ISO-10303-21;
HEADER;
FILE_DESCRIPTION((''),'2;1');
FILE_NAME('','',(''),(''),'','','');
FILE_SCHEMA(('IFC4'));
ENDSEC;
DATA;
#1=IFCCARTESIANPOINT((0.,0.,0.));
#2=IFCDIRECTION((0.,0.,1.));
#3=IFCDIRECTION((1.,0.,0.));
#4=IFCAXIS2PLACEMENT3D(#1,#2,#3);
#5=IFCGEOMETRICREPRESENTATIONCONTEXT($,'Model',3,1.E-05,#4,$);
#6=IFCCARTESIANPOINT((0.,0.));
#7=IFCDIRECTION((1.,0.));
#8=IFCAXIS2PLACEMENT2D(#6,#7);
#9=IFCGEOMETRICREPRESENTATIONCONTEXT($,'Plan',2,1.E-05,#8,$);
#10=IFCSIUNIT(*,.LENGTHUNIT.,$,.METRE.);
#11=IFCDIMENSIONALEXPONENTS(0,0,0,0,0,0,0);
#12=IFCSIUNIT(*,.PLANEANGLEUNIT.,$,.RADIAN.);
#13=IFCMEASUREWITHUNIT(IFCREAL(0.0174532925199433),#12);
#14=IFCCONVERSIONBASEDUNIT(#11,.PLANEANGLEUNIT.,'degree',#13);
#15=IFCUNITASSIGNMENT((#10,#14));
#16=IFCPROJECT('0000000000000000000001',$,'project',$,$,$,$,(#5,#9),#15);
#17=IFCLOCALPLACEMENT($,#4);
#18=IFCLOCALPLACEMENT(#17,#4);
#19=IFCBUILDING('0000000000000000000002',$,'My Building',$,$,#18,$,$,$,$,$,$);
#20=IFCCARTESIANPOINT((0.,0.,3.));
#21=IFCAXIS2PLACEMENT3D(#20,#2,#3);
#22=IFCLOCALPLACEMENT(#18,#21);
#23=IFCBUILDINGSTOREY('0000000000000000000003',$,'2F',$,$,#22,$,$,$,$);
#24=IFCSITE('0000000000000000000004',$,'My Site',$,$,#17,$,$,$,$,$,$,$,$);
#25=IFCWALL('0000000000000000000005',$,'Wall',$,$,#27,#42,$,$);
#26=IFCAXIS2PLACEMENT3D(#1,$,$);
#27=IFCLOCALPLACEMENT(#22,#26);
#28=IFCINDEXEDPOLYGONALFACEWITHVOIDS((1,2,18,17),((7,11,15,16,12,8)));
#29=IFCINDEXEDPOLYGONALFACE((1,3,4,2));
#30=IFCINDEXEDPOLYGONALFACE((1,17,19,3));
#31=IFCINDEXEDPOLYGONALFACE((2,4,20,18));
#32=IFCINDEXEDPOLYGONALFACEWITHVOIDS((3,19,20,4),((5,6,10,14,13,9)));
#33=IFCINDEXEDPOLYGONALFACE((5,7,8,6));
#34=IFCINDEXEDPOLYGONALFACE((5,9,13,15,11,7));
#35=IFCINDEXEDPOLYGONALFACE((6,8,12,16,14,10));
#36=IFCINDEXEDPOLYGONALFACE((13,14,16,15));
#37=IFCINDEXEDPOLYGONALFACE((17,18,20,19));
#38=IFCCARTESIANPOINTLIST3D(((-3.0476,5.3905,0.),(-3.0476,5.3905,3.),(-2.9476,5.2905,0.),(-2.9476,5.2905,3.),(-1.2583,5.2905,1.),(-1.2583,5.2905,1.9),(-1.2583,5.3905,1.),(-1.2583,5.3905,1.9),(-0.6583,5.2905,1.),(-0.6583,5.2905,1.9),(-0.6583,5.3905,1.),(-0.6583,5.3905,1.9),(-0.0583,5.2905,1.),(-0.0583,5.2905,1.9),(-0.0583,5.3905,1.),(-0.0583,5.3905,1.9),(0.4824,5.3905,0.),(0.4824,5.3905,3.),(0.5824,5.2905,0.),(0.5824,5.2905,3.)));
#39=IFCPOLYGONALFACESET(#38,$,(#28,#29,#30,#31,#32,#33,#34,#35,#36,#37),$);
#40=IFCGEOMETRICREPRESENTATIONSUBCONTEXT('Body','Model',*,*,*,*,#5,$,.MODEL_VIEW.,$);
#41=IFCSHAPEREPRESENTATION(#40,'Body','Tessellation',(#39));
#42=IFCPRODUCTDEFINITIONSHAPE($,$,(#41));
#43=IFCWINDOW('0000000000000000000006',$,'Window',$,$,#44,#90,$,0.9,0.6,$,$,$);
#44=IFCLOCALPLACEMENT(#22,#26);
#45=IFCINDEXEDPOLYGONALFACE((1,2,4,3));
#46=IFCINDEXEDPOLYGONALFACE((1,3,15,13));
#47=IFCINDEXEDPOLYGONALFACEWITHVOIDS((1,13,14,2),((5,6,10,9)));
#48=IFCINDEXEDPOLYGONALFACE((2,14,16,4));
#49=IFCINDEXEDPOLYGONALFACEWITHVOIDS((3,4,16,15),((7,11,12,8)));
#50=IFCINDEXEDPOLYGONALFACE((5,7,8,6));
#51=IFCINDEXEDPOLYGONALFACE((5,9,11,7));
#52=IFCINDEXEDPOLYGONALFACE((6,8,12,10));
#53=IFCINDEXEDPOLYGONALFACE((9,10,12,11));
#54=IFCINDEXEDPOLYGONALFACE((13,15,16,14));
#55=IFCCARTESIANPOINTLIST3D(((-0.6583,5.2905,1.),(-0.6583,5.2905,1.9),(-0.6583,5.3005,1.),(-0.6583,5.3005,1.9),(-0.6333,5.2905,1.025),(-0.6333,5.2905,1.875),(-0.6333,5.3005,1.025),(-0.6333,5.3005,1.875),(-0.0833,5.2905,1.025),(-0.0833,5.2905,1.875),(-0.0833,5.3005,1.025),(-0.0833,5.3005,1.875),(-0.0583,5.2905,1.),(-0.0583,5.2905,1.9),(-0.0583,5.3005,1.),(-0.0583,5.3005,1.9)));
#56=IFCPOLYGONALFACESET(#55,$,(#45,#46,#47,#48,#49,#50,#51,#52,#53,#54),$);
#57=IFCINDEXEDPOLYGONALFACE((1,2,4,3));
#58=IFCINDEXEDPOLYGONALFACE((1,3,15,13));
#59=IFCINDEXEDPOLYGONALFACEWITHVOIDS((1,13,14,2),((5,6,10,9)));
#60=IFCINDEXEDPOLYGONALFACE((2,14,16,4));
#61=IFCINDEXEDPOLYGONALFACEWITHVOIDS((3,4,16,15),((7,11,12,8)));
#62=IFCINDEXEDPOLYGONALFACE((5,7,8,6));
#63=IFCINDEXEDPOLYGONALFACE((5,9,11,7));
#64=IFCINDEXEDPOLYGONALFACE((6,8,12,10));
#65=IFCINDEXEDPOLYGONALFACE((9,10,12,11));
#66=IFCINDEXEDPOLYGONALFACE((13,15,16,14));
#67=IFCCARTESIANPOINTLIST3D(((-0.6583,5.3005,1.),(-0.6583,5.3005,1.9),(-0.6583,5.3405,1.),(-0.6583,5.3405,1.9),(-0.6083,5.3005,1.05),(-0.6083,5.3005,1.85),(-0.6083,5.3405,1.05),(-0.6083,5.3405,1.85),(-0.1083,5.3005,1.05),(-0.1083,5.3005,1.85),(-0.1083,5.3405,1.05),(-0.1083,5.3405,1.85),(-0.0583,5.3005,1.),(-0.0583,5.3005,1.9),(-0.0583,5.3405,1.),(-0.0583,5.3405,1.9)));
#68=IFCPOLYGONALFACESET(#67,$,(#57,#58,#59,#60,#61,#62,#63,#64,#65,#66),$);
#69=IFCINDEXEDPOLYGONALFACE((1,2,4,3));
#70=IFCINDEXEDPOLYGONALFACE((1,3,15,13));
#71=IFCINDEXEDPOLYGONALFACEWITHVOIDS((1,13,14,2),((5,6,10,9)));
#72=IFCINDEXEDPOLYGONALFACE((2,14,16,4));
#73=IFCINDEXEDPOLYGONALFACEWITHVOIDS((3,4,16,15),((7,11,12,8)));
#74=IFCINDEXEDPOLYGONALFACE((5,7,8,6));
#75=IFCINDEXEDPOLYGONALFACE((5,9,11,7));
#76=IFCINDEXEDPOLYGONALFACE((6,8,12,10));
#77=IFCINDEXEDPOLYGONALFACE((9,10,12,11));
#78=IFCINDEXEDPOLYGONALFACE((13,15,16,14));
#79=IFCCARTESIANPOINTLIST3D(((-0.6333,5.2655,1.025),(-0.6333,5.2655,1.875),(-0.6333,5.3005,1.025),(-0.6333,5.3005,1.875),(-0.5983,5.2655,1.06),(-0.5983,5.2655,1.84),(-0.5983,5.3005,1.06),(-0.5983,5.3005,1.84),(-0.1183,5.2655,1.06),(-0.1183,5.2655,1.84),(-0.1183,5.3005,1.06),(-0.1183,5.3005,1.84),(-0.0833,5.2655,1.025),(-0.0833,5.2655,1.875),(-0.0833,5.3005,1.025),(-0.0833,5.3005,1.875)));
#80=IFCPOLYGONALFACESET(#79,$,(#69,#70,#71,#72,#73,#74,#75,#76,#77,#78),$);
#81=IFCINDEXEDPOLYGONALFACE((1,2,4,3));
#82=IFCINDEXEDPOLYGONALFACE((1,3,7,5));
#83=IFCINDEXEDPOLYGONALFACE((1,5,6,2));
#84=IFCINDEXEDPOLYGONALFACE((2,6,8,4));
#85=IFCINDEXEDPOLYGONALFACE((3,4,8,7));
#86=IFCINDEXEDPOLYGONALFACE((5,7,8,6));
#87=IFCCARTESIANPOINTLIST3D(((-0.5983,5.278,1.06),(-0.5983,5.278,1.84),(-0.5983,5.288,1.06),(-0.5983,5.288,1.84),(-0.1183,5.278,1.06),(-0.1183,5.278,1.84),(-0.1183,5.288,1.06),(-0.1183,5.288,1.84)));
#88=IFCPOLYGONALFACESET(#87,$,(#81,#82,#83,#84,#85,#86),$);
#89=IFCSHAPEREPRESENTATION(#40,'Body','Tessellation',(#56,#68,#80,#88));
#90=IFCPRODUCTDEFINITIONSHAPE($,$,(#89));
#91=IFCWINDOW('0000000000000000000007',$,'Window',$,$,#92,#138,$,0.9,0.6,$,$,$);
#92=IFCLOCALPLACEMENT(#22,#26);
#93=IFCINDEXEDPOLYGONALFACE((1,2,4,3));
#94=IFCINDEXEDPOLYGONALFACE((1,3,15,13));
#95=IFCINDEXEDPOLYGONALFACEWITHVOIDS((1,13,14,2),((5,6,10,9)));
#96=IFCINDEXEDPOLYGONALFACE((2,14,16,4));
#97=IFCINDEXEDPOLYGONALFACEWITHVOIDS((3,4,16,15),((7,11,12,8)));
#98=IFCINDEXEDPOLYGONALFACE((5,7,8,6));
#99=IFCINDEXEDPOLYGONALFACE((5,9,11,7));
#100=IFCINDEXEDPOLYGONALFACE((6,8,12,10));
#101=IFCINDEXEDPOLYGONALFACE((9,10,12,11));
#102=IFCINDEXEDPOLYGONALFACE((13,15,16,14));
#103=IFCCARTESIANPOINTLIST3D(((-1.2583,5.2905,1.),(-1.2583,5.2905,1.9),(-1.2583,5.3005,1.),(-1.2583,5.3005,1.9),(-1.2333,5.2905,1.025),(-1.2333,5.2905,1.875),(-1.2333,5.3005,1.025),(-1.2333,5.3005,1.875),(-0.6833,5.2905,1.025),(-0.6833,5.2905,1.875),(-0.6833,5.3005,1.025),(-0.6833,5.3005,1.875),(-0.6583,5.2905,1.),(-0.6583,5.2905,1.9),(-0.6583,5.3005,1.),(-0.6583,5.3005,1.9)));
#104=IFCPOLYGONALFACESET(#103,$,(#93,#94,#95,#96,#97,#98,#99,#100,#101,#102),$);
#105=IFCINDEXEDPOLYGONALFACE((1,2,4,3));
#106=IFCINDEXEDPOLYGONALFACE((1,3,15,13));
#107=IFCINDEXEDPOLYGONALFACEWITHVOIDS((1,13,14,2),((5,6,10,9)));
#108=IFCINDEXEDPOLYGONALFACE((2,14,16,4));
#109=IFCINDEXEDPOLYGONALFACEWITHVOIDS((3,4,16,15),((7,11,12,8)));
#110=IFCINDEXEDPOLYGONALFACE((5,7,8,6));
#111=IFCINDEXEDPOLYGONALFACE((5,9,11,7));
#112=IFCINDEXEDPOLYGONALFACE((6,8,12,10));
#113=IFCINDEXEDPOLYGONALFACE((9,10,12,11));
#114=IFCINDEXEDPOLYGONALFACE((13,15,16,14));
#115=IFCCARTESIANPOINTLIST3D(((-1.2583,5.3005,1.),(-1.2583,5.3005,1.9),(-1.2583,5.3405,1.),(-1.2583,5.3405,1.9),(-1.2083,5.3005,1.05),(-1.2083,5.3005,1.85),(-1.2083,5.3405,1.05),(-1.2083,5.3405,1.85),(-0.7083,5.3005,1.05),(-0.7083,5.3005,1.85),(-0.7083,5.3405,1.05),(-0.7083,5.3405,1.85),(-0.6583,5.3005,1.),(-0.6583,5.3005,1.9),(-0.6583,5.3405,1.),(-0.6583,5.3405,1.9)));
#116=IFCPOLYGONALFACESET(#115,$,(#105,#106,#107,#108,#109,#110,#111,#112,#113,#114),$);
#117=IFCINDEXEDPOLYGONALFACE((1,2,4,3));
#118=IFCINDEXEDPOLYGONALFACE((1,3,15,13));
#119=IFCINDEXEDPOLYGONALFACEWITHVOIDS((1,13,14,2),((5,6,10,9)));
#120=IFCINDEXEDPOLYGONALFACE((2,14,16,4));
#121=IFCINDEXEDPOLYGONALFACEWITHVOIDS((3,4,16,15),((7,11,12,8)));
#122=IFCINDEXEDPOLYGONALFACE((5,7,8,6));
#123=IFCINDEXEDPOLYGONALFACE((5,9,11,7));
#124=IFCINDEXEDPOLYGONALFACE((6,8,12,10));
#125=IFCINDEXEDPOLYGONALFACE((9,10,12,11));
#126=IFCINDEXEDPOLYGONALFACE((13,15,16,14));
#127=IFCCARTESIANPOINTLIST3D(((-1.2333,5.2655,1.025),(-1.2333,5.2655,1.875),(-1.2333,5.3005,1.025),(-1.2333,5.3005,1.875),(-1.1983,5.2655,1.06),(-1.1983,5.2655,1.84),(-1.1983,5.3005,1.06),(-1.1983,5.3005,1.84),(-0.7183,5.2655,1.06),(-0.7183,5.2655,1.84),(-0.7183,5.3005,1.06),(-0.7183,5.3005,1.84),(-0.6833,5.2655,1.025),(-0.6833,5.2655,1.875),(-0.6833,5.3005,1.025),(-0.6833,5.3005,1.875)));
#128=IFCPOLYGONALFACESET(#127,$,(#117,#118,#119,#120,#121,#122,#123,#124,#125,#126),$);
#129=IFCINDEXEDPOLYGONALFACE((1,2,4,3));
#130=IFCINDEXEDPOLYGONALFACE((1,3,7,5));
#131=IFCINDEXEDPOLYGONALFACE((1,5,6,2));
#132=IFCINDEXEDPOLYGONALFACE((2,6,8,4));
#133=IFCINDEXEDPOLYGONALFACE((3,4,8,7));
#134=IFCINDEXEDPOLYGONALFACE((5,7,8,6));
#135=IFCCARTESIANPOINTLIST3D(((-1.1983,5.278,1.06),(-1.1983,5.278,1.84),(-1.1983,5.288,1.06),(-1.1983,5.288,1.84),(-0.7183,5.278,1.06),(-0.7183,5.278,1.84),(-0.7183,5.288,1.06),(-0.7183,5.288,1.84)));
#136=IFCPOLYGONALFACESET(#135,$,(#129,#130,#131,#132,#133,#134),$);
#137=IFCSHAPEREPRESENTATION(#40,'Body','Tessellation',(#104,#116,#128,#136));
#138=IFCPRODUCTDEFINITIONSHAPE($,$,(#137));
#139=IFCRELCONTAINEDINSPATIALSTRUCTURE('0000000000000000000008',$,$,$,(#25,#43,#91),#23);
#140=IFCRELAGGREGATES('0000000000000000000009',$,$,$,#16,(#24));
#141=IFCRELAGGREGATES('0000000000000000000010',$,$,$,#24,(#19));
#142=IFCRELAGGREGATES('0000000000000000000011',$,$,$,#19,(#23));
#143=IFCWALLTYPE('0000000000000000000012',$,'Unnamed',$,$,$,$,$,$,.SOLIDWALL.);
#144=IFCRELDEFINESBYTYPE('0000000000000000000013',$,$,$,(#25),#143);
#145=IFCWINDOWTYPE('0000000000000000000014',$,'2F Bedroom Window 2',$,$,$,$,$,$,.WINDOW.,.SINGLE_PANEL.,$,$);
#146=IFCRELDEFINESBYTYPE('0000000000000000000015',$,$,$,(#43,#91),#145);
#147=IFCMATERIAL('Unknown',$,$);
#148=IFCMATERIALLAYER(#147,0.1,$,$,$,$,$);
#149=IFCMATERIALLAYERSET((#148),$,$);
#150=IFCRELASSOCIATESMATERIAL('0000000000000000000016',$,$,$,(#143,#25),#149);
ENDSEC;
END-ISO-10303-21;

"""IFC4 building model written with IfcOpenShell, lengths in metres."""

from ifc_helpers import new_model, entity, si_unit, converted_unit, frame, origin_with_axes, origin_2d_with_axis, place, context, subcontext, project, spatial, line, indexed_curve, outline, extrude, shape, source, transform, mapped, material, layer, layer_set, layer_usage, type_object, type_shapes, element, fill, save


model = new_model("IFC4")

# Units and contexts
model_context = context("Model", 3, precision=1e-05, world=origin_with_axes())
plan_context = context("Plan", 2, precision=1e-05, world=origin_2d_with_axis())
body_context_1 = subcontext(model_context, "Body", "Model", "MODEL_VIEW")
body_context_2 = subcontext(plan_context, "Body", "Plan", "PLAN_VIEW")
ifc_project = project(units=[si_unit("LENGTHUNIT", "METRE"), converted_unit("PLANEANGLEUNIT", "degree", entity("IfcReal", 0.0174532925199433), si_unit("PLANEANGLEUNIT", "RADIAN"), dimensions=[0, 0, 0, 0, 0, 0, 0])], contexts=[model_context, plan_context])

# Site, building, storey
site_placement = place(None, origin_with_axes())
site = spatial("IfcSite", under=ifc_project, at=site_placement, Name="My Site")
building_placement = place(site_placement, origin_with_axes())
building = spatial("IfcBuilding", under=site, at=building_placement, Name="My Building")
storey_placement = place(building_placement, frame((0.0, 0.0, 3.0), z_axis=(0.0, 0.0, 1.0), x_axis=(1.0, 0.0, 0.0)))
storey = spatial("IfcBuildingStorey", under=building, at=storey_placement, Name="2F")

# Shared definitions
ifc_material = material(Name="Unknown")

# Shared definitions
ifc_layer = layer(ifc_material, 0.1)
ifc_layer_set = layer_set([ifc_layer])
wall_type = type_object("IfcWallType", Name="Unnamed", PredefinedType="SOLIDWALL", material=ifc_layer_set)

# Wall, openings, windows
ifc_layer_usage_1 = layer_usage(ifc_layer_set, "AXIS2", "POSITIVE", 0.0)
wall_1_placement = place(storey_placement, frame((0.4824, 5.3905, 0.0), z_axis=(0.0, 0.0, 1.0), x_axis=(-1.0, 0.0, 0.0)))
wall_1 = element("IfcWall", 1, at=wall_1_placement, inside=storey, type_object=wall_type, material=ifc_layer_usage_1, Name="Wall", context=body_context_1, shape_type="SweptSolid", body=[
    extrude(outline(indexed_curve([(0.0, 0.0), (-0.1, 0.1), (3.43, 0.1), (3.53, 0.0)], segments=[line(1, 2, 3, 4, 1)])), origin_with_axes(), (0.0, 0.0, 1.0), 3.0),
])
shared_shape_1 = source(origin_with_axes(), body_context_1, "Body", "SweptSolid", [
    extrude(outline(indexed_curve([(0.0, 0.0), (0.6, 0.0), (0.6, 0.9), (0.0, 0.9)], segments=[line(1, 2, 3, 4, 1)])), frame((0.0, -0.6, 0.0), z_axis=(0.0, -1.0, 0.0), x_axis=(1.0, 0.0, 0.0)), (0.0, 0.0, -1.0), 1.2),
])
opening_1_placement = place(wall_1_placement, frame((0.5406, 0.0, 1.0), z_axis=(0.0, 0.0, 1.0), x_axis=(1.0, 0.0, 0.0)))
opening_1 = element("IfcOpeningElement", 2, at=opening_1_placement, cuts=wall_1, PredefinedType="OPENING", context=body_context_1, shape_type="MappedRepresentation", body=[
    mapped(shared_shape_1, transform((0.0, 0.0, 0.0), x_axis=(1.0, 0.0, 0.0), y_axis=(0.0, 1.0, 0.0), z_axis=(0.0, 0.0, 1.0), scale=1.0)),
])
opening_2_placement = place(wall_1_placement, frame((1.1406, 0.0, 1.0), z_axis=(0.0, 0.0, 1.0), x_axis=(1.0, 0.0, 0.0)))
opening_2 = element("IfcOpeningElement", 3, at=opening_2_placement, cuts=wall_1, PredefinedType="OPENING", context=body_context_1, shape_type="MappedRepresentation", body=[
    mapped(shared_shape_1, transform((0.0, 0.0, 0.0), x_axis=(1.0, 0.0, 0.0), y_axis=(0.0, 1.0, 0.0), z_axis=(0.0, 0.0, 1.0), scale=1.0)),
])
window_type_1 = type_object("IfcWindowType", Name="2F Bedroom Window 2", PartitioningType="SINGLE_PANEL", PredefinedType="WINDOW")
shared_shape_2 = source(origin_with_axes(), body_context_1, "Body", "SweptSolid", [
    extrude(outline(indexed_curve([(0.0, 0.0), (0.6, 0.0), (0.6, 0.9), (0.0, 0.9)], segments=[line(1, 2, 3, 4, 1)]), holes=[indexed_curve([(0.025, 0.025), (0.575, 0.025), (0.575, 0.875), (0.025, 0.875)], segments=[line(1, 2, 3, 4, 1)])]), frame((0.0, 0.09, 0.0), z_axis=(0.0, -1.0, 0.0), x_axis=(1.0, 0.0, 0.0)), (0.0, 0.0, -1.0), 0.01),
    extrude(outline(indexed_curve([(0.0, 0.0), (0.6, 0.0), (0.6, 0.9), (0.0, 0.9)], segments=[line(1, 2, 3, 4, 1)]), holes=[indexed_curve([(0.05, 0.05), (0.55, 0.05), (0.55, 0.85), (0.05, 0.85)], segments=[line(1, 2, 3, 4, 1)])]), frame((0.0, 0.05, 0.0), z_axis=(0.0, -1.0, 0.0), x_axis=(1.0, 0.0, 0.0)), (0.0, 0.0, -1.0), 0.04),
    extrude(outline(indexed_curve([(0.0, 0.0), (0.55, 0.0), (0.55, 0.85), (0.0, 0.85)], segments=[line(1, 2, 3, 4, 1)]), holes=[indexed_curve([(0.035, 0.035), (0.515, 0.035), (0.515, 0.815), (0.035, 0.815)], segments=[line(1, 2, 3, 4, 1)])]), frame((0.025, 0.09, 0.025), z_axis=(0.0, -1.0, 0.0), x_axis=(1.0, 0.0, 0.0)), (0.0, 0.0, -1.0), 0.035),
    extrude(outline(indexed_curve([(0.035, 0.035), (0.515, 0.035), (0.515, 0.815), (0.035, 0.815)], segments=[line(1, 2, 3, 4, 1)])), frame((0.025, 0.1025, 0.025), z_axis=(0.0, -1.0, 0.0), x_axis=(1.0, 0.0, 0.0)), (0.0, 0.0, -1.0), 0.01),
])
shared_shape_3 = source(origin_with_axes(), body_context_2, "Body", "Curve2D", [
    entity("IfcIndexedPolyCurve", entity("IfcCartesianPointList2D", [[0.05, 0.05], [0.55, 0.05]])),
    entity("IfcIndexedPolyCurve", entity("IfcCartesianPointList2D", [[0.0, 0.1], [0.025, 0.1], [0.025, 0.09], [0.05, 0.09], [0.05, 0.05], [0.0, 0.05]]), [entity("IfcLineIndex", [1, 2, 3, 4, 5, 6, 1])]),
    entity("IfcIndexedPolyCurve", entity("IfcCartesianPointList2D", [[0.6, 0.1], [0.575, 0.1], [0.575, 0.09], [0.55, 0.09], [0.55, 0.05], [0.6, 0.05]]), [entity("IfcLineIndex", [1, 2, 3, 4, 5, 6, 1])]),
    entity("IfcIndexedPolyCurve", entity("IfcCartesianPointList2D", [[0.025, 0.09], [0.06, 0.09], [0.06, 0.125], [0.025, 0.125]]), [entity("IfcLineIndex", [1, 2, 3, 4, 1])]),
    entity("IfcIndexedPolyCurve", entity("IfcCartesianPointList2D", [[0.575, 0.09], [0.54, 0.09], [0.54, 0.125], [0.575, 0.125]]), [entity("IfcLineIndex", [1, 2, 3, 4, 1])]),
    entity("IfcIndexedPolyCurve", entity("IfcCartesianPointList2D", [[0.06, 0.09], [0.54, 0.09]])),
    entity("IfcIndexedPolyCurve", entity("IfcCartesianPointList2D", [[0.06, 0.125], [0.54, 0.125]])),
    entity("IfcIndexedPolyCurve", entity("IfcCartesianPointList2D", [[0.06, 0.1075], [0.54, 0.1075]])),
])
type_shapes(window_type_1, [shared_shape_2, shared_shape_3])
window_1_placement = place(opening_1_placement, frame((0.0, 0.0, 0.0), z_axis=(0.0, 0.0, 1.0), x_axis=(1.0, 0.0, 0.0)))
window_1 = element("IfcWindow", 4, at=window_1_placement, inside=storey, type_object=window_type_1, Name="Window", OverallHeight=0.9, OverallWidth=0.6, shapes=[
    shape(body_context_1, "Body", "MappedRepresentation", [mapped(shared_shape_2, transform((0.0, 0.0, 0.0), x_axis=(1.0, 0.0, 0.0), y_axis=(0.0, 1.0, 0.0), z_axis=(0.0, 0.0, 1.0), scale=1.0))]),
    shape(body_context_2, "Body", "MappedRepresentation", [mapped(shared_shape_3, transform((0.0, 0.0, 0.0), x_axis=(1.0, 0.0, 0.0), y_axis=(0.0, 1.0, 0.0), z_axis=(0.0, 0.0, 1.0), scale=1.0))]),
])
fill(opening_1, window_1)
window_2_placement = place(opening_2_placement, frame((0.0, 0.0, 0.0), z_axis=(0.0, 0.0, 1.0), x_axis=(1.0, 0.0, 0.0)))
window_2 = element("IfcWindow", 5, at=window_2_placement, inside=storey, type_object=window_type_1, Name="Window", OverallHeight=0.9, OverallWidth=0.6, shapes=[
    shape(body_context_1, "Body", "MappedRepresentation", [mapped(shared_shape_2, transform((0.0, 0.0, 0.0), x_axis=(1.0, 0.0, 0.0), y_axis=(0.0, 1.0, 0.0), z_axis=(0.0, 0.0, 1.0), scale=1.0))]),
    shape(body_context_2, "Body", "MappedRepresentation", [mapped(shared_shape_3, transform((0.0, 0.0, 0.0), x_axis=(1.0, 0.0, 0.0), y_axis=(0.0, 1.0, 0.0), z_axis=(0.0, 0.0, 1.0), scale=1.0))]),
])
fill(opening_2, window_2)

save(model, "model.ifc")
